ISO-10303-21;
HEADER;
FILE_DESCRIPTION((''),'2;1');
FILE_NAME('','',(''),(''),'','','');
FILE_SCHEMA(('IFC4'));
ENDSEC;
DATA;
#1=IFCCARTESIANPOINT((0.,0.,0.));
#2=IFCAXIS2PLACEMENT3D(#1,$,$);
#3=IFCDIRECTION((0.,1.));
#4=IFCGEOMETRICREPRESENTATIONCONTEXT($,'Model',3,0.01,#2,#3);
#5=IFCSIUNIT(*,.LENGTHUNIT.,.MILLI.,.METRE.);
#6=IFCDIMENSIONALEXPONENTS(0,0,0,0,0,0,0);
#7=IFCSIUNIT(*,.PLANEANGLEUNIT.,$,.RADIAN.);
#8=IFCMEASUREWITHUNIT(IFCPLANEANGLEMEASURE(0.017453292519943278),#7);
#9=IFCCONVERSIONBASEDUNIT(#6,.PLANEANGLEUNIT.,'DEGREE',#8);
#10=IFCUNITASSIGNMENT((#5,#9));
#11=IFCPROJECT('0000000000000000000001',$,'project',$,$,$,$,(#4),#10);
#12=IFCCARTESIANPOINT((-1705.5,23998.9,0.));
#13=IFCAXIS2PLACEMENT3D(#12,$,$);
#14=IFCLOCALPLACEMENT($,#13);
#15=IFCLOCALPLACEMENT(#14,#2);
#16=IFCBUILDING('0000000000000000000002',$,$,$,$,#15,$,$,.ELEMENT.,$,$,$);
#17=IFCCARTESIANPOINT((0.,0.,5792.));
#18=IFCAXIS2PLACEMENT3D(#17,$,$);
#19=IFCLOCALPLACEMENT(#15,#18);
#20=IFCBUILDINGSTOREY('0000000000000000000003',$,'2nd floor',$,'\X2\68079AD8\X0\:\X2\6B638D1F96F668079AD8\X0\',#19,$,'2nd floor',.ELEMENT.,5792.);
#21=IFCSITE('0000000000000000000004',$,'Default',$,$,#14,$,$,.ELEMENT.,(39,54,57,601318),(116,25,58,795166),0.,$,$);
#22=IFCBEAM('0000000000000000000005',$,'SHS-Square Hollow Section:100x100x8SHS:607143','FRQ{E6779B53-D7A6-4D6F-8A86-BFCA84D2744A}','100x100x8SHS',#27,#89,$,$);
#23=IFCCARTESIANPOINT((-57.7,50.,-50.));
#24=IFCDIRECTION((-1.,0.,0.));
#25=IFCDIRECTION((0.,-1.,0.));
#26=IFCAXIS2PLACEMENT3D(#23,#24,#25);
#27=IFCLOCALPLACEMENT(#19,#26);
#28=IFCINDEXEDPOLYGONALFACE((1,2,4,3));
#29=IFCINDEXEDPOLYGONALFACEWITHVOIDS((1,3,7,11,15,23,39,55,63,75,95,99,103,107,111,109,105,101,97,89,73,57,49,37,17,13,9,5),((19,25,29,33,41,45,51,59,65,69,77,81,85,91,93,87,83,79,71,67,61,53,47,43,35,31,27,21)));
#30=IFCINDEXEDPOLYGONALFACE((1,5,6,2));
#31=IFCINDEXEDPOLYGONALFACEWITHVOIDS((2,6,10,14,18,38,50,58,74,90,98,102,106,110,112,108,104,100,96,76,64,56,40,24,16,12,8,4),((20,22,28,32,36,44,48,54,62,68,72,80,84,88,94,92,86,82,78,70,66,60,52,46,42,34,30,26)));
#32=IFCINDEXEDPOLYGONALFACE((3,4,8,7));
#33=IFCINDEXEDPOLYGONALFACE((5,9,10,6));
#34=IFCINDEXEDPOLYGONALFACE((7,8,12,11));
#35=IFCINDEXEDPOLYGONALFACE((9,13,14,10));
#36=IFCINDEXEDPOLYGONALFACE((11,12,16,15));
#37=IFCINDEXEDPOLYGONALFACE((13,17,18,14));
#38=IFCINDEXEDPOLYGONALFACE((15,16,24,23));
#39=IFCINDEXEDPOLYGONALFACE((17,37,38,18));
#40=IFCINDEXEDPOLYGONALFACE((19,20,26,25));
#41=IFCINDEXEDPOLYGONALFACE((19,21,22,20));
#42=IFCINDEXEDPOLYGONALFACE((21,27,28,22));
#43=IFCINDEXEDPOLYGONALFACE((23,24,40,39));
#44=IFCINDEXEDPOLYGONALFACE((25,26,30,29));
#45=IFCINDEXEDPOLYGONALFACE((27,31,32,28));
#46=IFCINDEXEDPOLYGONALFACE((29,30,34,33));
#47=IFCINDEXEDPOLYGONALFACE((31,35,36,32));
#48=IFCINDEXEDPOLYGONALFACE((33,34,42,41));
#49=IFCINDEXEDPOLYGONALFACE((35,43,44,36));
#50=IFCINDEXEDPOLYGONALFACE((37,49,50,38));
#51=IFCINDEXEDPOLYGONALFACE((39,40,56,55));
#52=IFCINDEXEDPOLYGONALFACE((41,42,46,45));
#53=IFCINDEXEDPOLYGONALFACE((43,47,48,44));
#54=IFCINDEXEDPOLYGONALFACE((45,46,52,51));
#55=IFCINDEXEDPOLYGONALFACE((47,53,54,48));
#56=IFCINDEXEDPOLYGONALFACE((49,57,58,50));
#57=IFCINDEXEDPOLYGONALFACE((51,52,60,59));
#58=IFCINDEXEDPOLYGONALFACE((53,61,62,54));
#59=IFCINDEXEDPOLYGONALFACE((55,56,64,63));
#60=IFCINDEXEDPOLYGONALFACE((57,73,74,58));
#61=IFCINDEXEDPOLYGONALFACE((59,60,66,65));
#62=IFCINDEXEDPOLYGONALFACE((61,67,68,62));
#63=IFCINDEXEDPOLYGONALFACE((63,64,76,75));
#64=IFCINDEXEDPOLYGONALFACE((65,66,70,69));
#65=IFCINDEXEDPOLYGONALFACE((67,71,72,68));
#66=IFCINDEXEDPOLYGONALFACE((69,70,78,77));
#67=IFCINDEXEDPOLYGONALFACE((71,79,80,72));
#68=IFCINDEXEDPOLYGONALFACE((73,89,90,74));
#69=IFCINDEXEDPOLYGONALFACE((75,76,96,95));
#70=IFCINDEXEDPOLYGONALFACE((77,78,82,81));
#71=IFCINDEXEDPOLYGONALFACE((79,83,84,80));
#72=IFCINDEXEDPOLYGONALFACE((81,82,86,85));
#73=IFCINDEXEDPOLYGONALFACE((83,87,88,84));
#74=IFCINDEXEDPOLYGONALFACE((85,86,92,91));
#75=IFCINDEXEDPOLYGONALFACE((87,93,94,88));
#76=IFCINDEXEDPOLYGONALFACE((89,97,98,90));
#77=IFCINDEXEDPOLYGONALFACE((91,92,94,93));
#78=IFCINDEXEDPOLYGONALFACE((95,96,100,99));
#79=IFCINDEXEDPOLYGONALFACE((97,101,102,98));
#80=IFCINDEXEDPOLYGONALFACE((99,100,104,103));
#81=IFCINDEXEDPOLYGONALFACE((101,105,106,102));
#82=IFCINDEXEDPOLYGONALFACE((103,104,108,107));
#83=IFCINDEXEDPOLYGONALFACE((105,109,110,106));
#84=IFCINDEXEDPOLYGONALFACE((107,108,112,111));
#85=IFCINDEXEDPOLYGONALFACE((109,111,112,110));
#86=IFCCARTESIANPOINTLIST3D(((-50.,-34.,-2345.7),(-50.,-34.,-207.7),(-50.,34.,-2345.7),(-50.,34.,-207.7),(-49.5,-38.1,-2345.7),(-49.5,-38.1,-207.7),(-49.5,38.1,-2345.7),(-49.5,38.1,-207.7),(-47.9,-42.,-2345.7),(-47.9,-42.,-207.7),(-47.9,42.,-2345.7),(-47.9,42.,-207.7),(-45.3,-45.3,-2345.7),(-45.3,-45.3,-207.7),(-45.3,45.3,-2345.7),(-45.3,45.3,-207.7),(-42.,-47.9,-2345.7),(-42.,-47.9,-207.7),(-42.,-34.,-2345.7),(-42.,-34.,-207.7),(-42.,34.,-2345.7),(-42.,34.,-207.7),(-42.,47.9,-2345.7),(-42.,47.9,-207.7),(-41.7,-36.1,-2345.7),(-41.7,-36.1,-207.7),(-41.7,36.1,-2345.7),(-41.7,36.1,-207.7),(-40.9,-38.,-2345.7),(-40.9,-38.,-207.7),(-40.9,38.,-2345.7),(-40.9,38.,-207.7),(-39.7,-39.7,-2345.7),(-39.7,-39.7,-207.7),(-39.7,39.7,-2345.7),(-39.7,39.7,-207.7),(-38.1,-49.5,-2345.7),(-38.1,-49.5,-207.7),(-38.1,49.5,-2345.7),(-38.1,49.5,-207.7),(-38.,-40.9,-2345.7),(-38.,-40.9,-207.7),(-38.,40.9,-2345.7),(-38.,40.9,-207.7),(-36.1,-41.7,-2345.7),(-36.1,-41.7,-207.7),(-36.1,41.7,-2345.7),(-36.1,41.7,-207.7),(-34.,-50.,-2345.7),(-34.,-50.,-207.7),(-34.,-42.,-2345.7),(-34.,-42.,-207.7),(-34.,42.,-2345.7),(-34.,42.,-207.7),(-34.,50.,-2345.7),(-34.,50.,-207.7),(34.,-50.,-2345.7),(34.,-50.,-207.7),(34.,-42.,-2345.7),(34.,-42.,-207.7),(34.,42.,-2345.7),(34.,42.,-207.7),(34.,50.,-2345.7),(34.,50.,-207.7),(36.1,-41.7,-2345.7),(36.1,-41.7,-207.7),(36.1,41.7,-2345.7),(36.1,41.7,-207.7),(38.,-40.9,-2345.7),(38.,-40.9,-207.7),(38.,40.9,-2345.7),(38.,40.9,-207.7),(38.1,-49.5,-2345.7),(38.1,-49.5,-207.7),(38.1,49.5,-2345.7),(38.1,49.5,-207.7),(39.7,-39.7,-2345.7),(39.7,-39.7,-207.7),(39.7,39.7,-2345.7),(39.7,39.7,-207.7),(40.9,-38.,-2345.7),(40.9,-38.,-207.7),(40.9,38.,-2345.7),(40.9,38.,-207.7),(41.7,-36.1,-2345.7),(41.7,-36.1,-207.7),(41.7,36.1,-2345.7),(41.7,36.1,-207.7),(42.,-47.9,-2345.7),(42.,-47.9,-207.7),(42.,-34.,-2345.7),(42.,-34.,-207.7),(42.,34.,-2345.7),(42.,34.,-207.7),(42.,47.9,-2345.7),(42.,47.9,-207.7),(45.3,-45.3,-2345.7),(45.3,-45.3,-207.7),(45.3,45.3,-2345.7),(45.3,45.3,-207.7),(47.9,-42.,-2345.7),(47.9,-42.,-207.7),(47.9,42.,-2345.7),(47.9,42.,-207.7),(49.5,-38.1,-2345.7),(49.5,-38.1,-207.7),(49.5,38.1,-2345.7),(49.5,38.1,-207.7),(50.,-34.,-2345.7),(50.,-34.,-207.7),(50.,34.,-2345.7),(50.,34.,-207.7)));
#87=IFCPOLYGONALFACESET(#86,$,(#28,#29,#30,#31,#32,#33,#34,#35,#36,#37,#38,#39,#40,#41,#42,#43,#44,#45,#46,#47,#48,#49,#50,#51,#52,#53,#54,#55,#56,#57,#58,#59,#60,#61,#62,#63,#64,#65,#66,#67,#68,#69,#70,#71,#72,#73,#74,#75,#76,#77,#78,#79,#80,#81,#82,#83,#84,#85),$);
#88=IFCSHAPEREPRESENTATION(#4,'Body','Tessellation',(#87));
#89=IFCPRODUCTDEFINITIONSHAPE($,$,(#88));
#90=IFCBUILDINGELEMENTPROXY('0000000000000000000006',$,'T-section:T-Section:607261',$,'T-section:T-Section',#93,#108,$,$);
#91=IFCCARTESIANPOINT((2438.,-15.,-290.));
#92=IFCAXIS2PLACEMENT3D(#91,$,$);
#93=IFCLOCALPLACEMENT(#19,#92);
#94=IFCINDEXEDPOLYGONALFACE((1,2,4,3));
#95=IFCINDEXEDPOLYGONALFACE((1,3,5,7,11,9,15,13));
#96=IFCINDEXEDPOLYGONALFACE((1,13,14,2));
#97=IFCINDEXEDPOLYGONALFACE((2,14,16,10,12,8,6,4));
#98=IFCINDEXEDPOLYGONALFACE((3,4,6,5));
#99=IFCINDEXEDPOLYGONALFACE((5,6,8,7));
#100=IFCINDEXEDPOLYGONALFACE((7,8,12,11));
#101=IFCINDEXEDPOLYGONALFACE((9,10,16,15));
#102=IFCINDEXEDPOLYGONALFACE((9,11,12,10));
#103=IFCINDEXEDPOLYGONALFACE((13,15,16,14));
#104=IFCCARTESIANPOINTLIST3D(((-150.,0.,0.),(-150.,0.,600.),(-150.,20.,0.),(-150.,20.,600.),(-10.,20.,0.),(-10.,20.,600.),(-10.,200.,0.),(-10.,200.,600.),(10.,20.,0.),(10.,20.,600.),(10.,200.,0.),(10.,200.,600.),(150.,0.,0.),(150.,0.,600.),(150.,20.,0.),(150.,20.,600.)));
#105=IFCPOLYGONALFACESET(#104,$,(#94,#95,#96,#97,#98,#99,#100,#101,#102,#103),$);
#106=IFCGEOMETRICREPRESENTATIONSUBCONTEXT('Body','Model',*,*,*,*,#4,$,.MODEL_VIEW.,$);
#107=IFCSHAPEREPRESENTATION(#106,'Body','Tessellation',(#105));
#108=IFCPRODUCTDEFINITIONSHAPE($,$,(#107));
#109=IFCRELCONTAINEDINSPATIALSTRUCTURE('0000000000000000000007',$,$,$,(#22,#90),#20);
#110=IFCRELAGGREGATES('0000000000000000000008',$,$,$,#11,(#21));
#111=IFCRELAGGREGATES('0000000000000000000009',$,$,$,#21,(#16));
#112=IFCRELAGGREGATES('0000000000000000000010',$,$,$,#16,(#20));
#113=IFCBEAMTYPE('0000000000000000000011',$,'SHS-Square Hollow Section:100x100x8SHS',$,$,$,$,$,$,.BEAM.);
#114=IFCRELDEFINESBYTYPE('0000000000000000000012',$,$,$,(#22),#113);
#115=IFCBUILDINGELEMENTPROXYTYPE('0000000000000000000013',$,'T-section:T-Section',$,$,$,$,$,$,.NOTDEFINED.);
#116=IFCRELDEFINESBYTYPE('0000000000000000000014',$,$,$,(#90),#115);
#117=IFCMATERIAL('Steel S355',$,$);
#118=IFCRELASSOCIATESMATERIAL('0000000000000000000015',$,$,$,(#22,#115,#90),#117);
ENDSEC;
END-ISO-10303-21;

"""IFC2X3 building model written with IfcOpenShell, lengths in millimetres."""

from ifc_helpers import new_model, entity, si_unit, converted_unit, direction, frame, origin, origin_2d, place, context, subcontext, project, spatial, polyline, hollow_rectangle, outline, extrude, clip, halfspace, source, transform, mapped, material, type_object, type_shapes, element, save


model = new_model("IFC2X3")

# Units and contexts
model_context = context("Model", 3, precision=0.01, world=origin(), true_north=direction((0.0, 1.0)))
body_context = subcontext(model_context, "Body", "Model", "MODEL_VIEW")
ifc_project = project(units=[si_unit("LENGTHUNIT", "METRE", prefix="MILLI"), converted_unit("PLANEANGLEUNIT", "DEGREE", entity("IfcPlaneAngleMeasure", 0.017453292519943278), si_unit("PLANEANGLEUNIT", "RADIAN"), dimensions=[0, 0, 0, 0, 0, 0, 0])], contexts=[model_context])

# Site, building, storey
site_placement = place(None, frame((-1705.5, 23998.9, 0.0)))
site = spatial("IfcSite", under=ifc_project, at=site_placement, Name="Default", CompositionType="ELEMENT", RefLatitude=(39, 54, 57, 601318), RefLongitude=(116, 25, 58, 795166), RefElevation=0.0)
building_placement = place(site_placement, origin())
building = spatial("IfcBuilding", under=site, at=building_placement, CompositionType="ELEMENT")
storey_placement = place(building_placement, frame((0.0, 0.0, 5792.0)))
storey = spatial("IfcBuildingStorey", under=building, at=storey_placement, Name="2nd floor", ObjectType="标高:正负零标高", LongName="2nd floor", CompositionType="ELEMENT", Elevation=5792.0)

# Shared definitions
ifc_material_1 = material(Name="Steel S355")

# Beam
beam_type_1 = type_object("IfcBeamType", Name="SHS-Square Hollow Section:100x100x8SHS", PredefinedType="BEAM")
beam_1_placement = place(storey_placement, frame((-57.7, 50.0, -50.0), z_axis=(-1.0, 0.0, 0.0), x_axis=(0.0, -1.0, 0.0)))
element("IfcBeam", 1, at=beam_1_placement, inside=storey, type_object=beam_type_1, material=ifc_material_1, Name="SHS-Square Hollow Section:100x100x8SHS:607143", Description="FRQ{E6779B53-D7A6-4D6F-8A86-BFCA84D2744A}", ObjectType="100x100x8SHS", context=model_context, shape_type="Clipping", body=[
    clip(clip(extrude(hollow_rectangle(XDim=100.0, YDim=100.0, WallThickness=8.0, InnerFilletRadius=8.0, OuterFilletRadius=16.0, at=origin_2d()), origin(), (0.0, 0.0, -1.0), 2551.4), halfspace(frame((50.0, -5742.0, -207.7), z_axis=(0.0, 0.0, -1.0), x_axis=(-1.0, 0.0, 0.0)), True)), halfspace(frame((50.0, -5742.0, -2345.7), z_axis=(0.0, 0.0, 1.0), x_axis=(1.0, 0.0, 0.0)), True)),
])

# Building element proxy
building_element_proxy_type_1 = type_object("IfcBuildingElementProxyType", Name="T-section:T-Section", PredefinedType="NOTDEFINED", material=ifc_material_1)
shared_shape_1 = source(origin(), body_context, "Body", "SweptSolid", [
    extrude(outline(polyline([(-140.0, 10.0), (-140.0, -10.0), (40.0, -10.0), (40.0, -150.0), (60.0, -150.0), (60.0, 150.0), (40.0, 150.0), (40.0, 10.0), (-140.0, 10.0)])), frame((0.0, 60.0, 0.0), z_axis=(0.0, 0.0, -1.0), x_axis=(0.0, -1.0, 0.0)), (0.0, 0.0, -1.0), 600.0),
])
type_shapes(building_element_proxy_type_1, [shared_shape_1])
proxy_placement = place(storey_placement, frame((2438.0, -15.0, -290.0)))
element("IfcBuildingElementProxy", 2, at=proxy_placement, inside=storey, type_object=building_element_proxy_type_1, material=ifc_material_1, Name="T-section:T-Section:607261", ObjectType="T-section:T-Section", context=body_context, shape_type="MappedRepresentation", body=[
    mapped(shared_shape_1, transform((0.0, 0.0, 0.0), scale=1.0)),
])

save(model, "model.ifc")
